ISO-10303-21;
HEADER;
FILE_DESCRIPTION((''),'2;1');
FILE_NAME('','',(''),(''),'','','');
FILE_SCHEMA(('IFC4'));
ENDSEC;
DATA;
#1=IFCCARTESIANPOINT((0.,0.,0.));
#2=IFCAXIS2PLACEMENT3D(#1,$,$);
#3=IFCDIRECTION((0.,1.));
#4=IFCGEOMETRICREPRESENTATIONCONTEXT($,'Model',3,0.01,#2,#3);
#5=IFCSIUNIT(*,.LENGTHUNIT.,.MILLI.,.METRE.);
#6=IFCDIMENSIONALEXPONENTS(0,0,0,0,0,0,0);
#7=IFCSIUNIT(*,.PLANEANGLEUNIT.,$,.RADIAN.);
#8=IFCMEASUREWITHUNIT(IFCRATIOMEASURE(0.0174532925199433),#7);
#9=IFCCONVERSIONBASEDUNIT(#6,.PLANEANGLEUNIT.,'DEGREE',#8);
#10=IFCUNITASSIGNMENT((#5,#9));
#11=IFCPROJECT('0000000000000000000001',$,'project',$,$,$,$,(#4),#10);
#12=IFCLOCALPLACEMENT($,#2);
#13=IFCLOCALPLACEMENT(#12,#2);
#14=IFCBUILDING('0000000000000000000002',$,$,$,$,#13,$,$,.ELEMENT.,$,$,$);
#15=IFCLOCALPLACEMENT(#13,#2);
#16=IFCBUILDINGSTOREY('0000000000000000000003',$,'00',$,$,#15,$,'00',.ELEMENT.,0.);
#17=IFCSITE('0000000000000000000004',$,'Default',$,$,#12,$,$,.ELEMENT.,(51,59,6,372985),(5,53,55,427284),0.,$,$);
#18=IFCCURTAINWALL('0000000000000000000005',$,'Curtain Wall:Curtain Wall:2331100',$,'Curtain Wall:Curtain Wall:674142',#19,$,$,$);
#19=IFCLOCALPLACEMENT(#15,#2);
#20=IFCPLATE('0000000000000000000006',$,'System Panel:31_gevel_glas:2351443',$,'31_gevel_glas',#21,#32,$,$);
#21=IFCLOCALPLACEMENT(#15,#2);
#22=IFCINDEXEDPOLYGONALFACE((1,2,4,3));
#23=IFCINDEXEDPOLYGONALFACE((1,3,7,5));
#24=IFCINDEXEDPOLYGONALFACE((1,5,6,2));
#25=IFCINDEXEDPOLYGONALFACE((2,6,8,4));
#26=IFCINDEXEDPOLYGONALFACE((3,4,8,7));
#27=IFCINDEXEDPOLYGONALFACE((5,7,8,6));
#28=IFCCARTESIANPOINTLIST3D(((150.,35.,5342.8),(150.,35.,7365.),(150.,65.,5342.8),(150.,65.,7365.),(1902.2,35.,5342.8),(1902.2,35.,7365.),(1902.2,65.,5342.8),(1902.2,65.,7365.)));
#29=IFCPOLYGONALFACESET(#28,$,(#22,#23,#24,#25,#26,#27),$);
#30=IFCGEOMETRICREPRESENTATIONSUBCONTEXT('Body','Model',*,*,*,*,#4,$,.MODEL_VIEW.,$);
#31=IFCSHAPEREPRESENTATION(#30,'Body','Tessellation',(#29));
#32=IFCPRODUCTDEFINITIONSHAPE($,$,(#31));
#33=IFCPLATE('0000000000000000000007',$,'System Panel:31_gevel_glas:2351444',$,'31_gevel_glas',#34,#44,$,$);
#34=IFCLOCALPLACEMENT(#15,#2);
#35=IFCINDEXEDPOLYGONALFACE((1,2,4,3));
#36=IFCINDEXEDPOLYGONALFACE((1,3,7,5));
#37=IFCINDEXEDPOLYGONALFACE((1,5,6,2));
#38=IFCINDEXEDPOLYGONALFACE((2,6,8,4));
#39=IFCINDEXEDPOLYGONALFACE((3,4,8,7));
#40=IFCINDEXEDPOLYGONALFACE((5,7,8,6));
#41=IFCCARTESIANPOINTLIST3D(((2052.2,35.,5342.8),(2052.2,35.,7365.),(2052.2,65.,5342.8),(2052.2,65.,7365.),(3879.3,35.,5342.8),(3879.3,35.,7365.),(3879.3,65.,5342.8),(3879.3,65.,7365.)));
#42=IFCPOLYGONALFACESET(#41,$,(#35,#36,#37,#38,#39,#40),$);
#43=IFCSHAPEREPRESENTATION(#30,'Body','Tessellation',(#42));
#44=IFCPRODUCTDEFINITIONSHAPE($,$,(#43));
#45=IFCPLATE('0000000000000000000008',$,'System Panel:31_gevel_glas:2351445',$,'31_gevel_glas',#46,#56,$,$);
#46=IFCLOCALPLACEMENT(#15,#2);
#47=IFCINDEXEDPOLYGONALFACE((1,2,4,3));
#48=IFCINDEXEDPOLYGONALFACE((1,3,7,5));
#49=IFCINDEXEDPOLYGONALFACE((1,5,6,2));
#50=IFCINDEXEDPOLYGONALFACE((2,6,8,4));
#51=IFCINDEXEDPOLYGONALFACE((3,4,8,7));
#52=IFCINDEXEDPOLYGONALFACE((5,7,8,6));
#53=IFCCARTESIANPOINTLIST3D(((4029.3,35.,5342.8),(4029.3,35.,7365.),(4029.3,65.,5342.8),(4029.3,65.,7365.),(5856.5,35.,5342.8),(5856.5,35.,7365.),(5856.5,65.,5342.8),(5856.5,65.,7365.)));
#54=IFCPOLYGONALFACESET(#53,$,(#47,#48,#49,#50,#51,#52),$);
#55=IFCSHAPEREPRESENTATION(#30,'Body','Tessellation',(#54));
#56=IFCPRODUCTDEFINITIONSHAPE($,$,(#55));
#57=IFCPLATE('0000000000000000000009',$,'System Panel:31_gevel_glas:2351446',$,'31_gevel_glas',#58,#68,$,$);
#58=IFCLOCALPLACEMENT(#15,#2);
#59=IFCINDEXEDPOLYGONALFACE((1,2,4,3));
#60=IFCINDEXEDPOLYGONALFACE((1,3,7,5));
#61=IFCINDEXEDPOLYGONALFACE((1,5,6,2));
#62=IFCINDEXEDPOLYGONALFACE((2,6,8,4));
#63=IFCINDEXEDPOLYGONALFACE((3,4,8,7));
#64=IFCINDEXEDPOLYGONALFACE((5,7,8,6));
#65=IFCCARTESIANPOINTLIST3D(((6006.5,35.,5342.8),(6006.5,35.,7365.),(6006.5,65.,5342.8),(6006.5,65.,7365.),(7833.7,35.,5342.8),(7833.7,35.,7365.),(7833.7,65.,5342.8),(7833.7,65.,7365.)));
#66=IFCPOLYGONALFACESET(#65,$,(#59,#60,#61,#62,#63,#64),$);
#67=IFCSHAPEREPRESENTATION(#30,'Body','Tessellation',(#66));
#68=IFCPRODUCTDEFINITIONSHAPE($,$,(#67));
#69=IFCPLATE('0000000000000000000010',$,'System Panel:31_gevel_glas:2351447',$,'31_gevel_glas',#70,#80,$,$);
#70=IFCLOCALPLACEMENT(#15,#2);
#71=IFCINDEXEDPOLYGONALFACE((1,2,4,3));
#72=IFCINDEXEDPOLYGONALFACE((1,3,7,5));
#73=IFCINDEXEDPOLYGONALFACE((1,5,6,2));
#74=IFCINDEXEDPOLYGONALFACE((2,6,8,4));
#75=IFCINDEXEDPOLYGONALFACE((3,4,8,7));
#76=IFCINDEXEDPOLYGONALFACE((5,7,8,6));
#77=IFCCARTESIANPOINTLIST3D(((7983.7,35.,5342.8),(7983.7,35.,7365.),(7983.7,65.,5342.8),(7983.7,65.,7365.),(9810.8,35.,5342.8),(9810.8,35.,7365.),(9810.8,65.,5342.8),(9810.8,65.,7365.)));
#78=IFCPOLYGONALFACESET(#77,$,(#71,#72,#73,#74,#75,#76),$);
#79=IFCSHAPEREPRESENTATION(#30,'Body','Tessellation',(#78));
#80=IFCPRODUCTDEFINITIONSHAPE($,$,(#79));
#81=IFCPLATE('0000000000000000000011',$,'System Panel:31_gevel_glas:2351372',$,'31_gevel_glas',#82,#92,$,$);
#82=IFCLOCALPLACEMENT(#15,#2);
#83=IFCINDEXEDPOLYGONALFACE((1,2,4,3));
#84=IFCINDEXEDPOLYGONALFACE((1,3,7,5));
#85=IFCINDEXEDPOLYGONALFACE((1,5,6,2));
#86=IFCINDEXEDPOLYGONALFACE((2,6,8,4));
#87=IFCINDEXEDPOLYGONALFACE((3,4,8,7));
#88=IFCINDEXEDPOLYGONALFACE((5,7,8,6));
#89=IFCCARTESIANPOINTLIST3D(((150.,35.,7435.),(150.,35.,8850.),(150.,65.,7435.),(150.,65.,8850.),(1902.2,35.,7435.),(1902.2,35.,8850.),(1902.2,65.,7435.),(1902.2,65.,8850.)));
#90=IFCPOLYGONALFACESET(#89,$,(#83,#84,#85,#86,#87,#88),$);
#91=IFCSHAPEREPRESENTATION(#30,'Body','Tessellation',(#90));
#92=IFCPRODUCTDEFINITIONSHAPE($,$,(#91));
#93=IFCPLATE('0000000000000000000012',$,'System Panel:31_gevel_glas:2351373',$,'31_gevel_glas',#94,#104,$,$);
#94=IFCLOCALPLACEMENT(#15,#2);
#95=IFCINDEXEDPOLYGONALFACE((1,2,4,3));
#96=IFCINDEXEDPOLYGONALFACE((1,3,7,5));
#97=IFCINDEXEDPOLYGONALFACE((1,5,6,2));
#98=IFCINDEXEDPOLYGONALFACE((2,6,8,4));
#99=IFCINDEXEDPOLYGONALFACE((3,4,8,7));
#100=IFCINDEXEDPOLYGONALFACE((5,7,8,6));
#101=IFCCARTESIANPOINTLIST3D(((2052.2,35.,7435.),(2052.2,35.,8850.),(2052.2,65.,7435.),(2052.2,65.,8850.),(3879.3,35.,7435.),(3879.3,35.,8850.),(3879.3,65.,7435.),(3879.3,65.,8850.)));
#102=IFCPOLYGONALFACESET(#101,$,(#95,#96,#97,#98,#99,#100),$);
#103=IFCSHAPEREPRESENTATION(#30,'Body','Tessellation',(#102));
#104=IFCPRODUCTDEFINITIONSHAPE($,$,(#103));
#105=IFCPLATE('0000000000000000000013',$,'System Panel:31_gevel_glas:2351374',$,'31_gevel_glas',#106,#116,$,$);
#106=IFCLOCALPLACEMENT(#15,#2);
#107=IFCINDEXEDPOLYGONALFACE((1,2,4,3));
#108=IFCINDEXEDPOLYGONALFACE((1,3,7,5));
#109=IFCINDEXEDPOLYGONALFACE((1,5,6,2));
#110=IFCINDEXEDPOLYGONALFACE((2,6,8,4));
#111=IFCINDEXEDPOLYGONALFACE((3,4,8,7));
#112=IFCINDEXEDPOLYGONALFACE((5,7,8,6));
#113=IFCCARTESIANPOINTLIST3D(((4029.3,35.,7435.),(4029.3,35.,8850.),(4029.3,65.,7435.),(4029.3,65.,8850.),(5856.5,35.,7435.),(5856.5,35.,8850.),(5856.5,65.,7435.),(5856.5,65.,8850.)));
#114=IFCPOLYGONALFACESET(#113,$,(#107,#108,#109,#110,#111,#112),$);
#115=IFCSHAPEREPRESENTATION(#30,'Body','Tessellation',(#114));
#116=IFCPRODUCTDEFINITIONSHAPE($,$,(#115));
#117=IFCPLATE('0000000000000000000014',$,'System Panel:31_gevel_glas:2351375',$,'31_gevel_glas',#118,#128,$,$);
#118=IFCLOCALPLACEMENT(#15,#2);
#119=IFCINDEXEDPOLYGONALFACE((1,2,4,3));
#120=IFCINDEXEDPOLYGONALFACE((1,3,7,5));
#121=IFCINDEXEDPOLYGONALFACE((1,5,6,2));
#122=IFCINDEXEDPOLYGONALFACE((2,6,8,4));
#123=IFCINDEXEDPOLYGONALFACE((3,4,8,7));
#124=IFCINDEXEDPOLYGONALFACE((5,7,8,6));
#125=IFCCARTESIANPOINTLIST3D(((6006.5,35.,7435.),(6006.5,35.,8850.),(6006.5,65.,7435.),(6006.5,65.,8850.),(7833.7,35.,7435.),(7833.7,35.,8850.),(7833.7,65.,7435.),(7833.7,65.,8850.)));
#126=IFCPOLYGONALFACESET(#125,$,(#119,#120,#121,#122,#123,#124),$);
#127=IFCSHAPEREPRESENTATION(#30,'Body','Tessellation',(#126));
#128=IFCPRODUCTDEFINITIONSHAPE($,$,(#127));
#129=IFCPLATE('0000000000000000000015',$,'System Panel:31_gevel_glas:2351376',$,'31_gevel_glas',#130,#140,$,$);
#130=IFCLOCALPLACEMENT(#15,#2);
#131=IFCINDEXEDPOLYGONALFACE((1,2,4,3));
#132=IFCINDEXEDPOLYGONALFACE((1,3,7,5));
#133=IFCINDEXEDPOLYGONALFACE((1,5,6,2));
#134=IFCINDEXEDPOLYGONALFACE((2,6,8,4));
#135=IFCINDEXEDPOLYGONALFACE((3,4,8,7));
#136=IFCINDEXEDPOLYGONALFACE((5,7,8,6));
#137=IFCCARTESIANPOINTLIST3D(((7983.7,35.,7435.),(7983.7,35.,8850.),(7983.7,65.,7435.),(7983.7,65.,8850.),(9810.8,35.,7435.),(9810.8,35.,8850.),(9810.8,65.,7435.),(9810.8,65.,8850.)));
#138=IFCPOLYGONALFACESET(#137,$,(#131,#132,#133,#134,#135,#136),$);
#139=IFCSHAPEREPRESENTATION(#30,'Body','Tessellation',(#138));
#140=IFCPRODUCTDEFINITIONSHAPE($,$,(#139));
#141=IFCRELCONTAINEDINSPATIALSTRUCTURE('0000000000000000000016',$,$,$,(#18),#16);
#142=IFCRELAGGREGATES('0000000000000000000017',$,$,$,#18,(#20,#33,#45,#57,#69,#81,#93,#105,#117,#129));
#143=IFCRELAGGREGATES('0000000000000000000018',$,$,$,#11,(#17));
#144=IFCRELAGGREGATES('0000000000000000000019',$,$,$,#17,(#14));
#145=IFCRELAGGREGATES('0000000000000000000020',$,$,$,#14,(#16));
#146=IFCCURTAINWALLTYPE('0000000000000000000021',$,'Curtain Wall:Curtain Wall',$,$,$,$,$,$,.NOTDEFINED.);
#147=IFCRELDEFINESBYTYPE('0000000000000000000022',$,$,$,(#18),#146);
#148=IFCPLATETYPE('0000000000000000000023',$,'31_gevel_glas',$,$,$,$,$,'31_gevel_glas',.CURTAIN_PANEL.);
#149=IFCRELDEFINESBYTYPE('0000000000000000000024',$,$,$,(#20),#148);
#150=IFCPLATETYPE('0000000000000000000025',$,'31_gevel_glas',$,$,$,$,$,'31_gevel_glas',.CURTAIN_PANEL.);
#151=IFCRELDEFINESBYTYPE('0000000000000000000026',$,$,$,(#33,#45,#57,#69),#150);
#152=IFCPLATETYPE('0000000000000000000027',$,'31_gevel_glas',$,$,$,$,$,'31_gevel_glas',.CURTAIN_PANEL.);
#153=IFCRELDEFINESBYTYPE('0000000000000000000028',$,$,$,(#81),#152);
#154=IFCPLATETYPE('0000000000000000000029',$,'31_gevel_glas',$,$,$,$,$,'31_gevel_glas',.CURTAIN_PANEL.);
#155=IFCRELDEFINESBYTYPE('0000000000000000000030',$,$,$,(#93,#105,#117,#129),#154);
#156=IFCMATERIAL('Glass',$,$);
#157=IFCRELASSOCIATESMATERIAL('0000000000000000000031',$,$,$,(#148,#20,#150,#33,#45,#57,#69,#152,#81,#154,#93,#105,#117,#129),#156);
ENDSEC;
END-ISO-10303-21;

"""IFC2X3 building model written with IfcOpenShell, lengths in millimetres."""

from ifc_helpers import new_model, entity, si_unit, converted_unit, direction, frame, frame_2d, origin, origin_2d_with_axis, place, context, subcontext, project, spatial, rectangle, extrude, source, transform, mapped, material, type_object, type_shapes, element, aggregate, save


model = new_model("IFC2X3")

# Units and contexts
model_context = context("Model", 3, precision=0.01, world=origin(), true_north=direction((0.0, 1.0)))
body_context = subcontext(model_context, "Body", "Model", "MODEL_VIEW")
ifc_project = project(units=[si_unit("LENGTHUNIT", "METRE", prefix="MILLI"), converted_unit("PLANEANGLEUNIT", "DEGREE", entity("IfcRatioMeasure", 0.0174532925199433), si_unit("PLANEANGLEUNIT", "RADIAN"), dimensions=[0, 0, 0, 0, 0, 0, 0])], contexts=[model_context])

# Site, building, storey
site_placement = place(None, origin())
site = spatial("IfcSite", under=ifc_project, at=site_placement, Name="Default", CompositionType="ELEMENT", RefLatitude=(51, 59, 6, 372985), RefLongitude=(5, 53, 55, 427284), RefElevation=0.0)
building_placement = place(site_placement, origin())
building = spatial("IfcBuilding", under=site, at=building_placement, CompositionType="ELEMENT")
storey_placement = place(building_placement, origin())
storey = spatial("IfcBuildingStorey", under=building, at=storey_placement, Name="00", LongName="00", CompositionType="ELEMENT", Elevation=0.0)

# Curtain wall, plates
curtain_wall_type = type_object("IfcCurtainWallType", Name="Curtain Wall:Curtain Wall", PredefinedType="NOTDEFINED")
curtain_wall_placement = place(storey_placement, origin())
curtain_wall = element("IfcCurtainWall", 1, at=curtain_wall_placement, inside=storey, type_object=curtain_wall_type, Name="Curtain Wall:Curtain Wall:2331100", ObjectType="Curtain Wall:Curtain Wall:674142")
ifc_material = material(Name="Glass")
plate_type_1 = type_object("IfcPlateType", Name="31_gevel_glas", ElementType="31_gevel_glas", PredefinedType="CURTAIN_PANEL", material=ifc_material)
shared_shape_1 = source(origin(), body_context, "Body", "SweptSolid", [
    extrude(rectangle(XDim=30.0, YDim=1752.2, at=origin_2d_with_axis()), frame((0.0, 50.0, 0.0), z_axis=(0.0, 0.0, 1.0), x_axis=(0.0, 1.0, 0.0)), (0.0, 0.0, 1.0), 2022.2),
])
type_shapes(plate_type_1, [shared_shape_1])
plate_1_placement = place(curtain_wall_placement, frame((1026.1, 0.0, 5342.8)))
plate_1 = element("IfcPlate", 2, at=plate_1_placement, type_object=plate_type_1, material=ifc_material, Name="System Panel:31_gevel_glas:2351443", ObjectType="31_gevel_glas", context=body_context, shape_type="MappedRepresentation", body=[
    mapped(shared_shape_1, transform((0.0, 0.0, 0.0), scale=1.0)),
])
plate_type_2 = type_object("IfcPlateType", Name="31_gevel_glas", ElementType="31_gevel_glas", PredefinedType="CURTAIN_PANEL", material=ifc_material)
shared_shape_2 = source(origin(), body_context, "Body", "SweptSolid", [
    extrude(rectangle(XDim=30.0, YDim=1827.2, at=origin_2d_with_axis()), frame((0.0, 50.0, 0.0), z_axis=(0.0, 0.0, 1.0), x_axis=(0.0, 1.0, 0.0)), (0.0, 0.0, 1.0), 2022.2),
])
type_shapes(plate_type_2, [shared_shape_2])
plate_2_placement = place(curtain_wall_placement, frame((2965.7, 0.0, 5342.8)))
plate_2 = element("IfcPlate", 3, at=plate_2_placement, type_object=plate_type_2, material=ifc_material, Name="System Panel:31_gevel_glas:2351444", ObjectType="31_gevel_glas", context=body_context, shape_type="MappedRepresentation", body=[
    mapped(shared_shape_2, transform((0.0, 0.0, 0.0), scale=1.0)),
])
plate_3_placement = place(curtain_wall_placement, frame((4942.9, 0.0, 5342.8)))
plate_3 = element("IfcPlate", 4, at=plate_3_placement, type_object=plate_type_2, material=ifc_material, Name="System Panel:31_gevel_glas:2351445", ObjectType="31_gevel_glas", context=body_context, shape_type="MappedRepresentation", body=[
    mapped(shared_shape_2, transform((0.0, 0.0, 0.0), scale=1.0)),
])
plate_4_placement = place(curtain_wall_placement, frame((6920.1, 0.0, 5342.8)))
plate_4 = element("IfcPlate", 5, at=plate_4_placement, type_object=plate_type_2, material=ifc_material, Name="System Panel:31_gevel_glas:2351446", ObjectType="31_gevel_glas", context=body_context, shape_type="MappedRepresentation", body=[
    mapped(shared_shape_2, transform((0.0, 0.0, 0.0), scale=1.0)),
])
plate_5_placement = place(curtain_wall_placement, frame((8897.2, 0.0, 5342.8)))
plate_5 = element("IfcPlate", 6, at=plate_5_placement, type_object=plate_type_2, material=ifc_material, Name="System Panel:31_gevel_glas:2351447", ObjectType="31_gevel_glas", context=body_context, shape_type="MappedRepresentation", body=[
    mapped(shared_shape_2, transform((0.0, 0.0, 0.0), scale=1.0)),
])
plate_type_3 = type_object("IfcPlateType", Name="31_gevel_glas", ElementType="31_gevel_glas", PredefinedType="CURTAIN_PANEL", material=ifc_material)
shared_shape_3 = source(origin(), body_context, "Body", "SweptSolid", [
    extrude(rectangle(XDim=30.0, YDim=1752.2, at=frame_2d((0.0, 0.0), x_axis=(1.0, 0.0))), frame((0.0, 50.0, 0.0), z_axis=(0.0, 0.0, 1.0), x_axis=(0.0, 1.0, 0.0)), (0.0, 0.0, 1.0), 1415.0),
])
type_shapes(plate_type_3, [shared_shape_3])
plate_6_placement = place(curtain_wall_placement, frame((1026.1, 0.0, 7435.0)))
plate_6 = element("IfcPlate", 7, at=plate_6_placement, type_object=plate_type_3, material=ifc_material, Name="System Panel:31_gevel_glas:2351372", ObjectType="31_gevel_glas", context=body_context, shape_type="MappedRepresentation", body=[
    mapped(shared_shape_3, transform((0.0, 0.0, 0.0), scale=1.0)),
])
plate_type_4 = type_object("IfcPlateType", Name="31_gevel_glas", ElementType="31_gevel_glas", PredefinedType="CURTAIN_PANEL", material=ifc_material)
shared_shape_4 = source(origin(), body_context, "Body", "SweptSolid", [
    extrude(rectangle(XDim=30.0, YDim=1827.2, at=origin_2d_with_axis()), frame((0.0, 50.0, 0.0), z_axis=(0.0, 0.0, 1.0), x_axis=(0.0, 1.0, 0.0)), (0.0, 0.0, 1.0), 1415.0),
])
type_shapes(plate_type_4, [shared_shape_4])
plate_7_placement = place(curtain_wall_placement, frame((2965.7, 0.0, 7435.0)))
plate_7 = element("IfcPlate", 8, at=plate_7_placement, type_object=plate_type_4, material=ifc_material, Name="System Panel:31_gevel_glas:2351373", ObjectType="31_gevel_glas", context=body_context, shape_type="MappedRepresentation", body=[
    mapped(shared_shape_4, transform((0.0, 0.0, 0.0), scale=1.0)),
])
plate_8_placement = place(curtain_wall_placement, frame((4942.9, 0.0, 7435.0)))
plate_8 = element("IfcPlate", 9, at=plate_8_placement, type_object=plate_type_4, material=ifc_material, Name="System Panel:31_gevel_glas:2351374", ObjectType="31_gevel_glas", context=body_context, shape_type="MappedRepresentation", body=[
    mapped(shared_shape_4, transform((0.0, 0.0, 0.0), scale=1.0)),
])
plate_9_placement = place(curtain_wall_placement, frame((6920.1, 0.0, 7435.0)))
plate_9 = element("IfcPlate", 10, at=plate_9_placement, type_object=plate_type_4, material=ifc_material, Name="System Panel:31_gevel_glas:2351375", ObjectType="31_gevel_glas", context=body_context, shape_type="MappedRepresentation", body=[
    mapped(shared_shape_4, transform((0.0, 0.0, 0.0), scale=1.0)),
])
plate_10_placement = place(curtain_wall_placement, frame((8897.2, 0.0, 7435.0)))
plate_10 = element("IfcPlate", 11, at=plate_10_placement, type_object=plate_type_4, material=ifc_material, Name="System Panel:31_gevel_glas:2351376", ObjectType="31_gevel_glas", context=body_context, shape_type="MappedRepresentation", body=[
    mapped(shared_shape_4, transform((0.0, 0.0, 0.0), scale=1.0)),
])
aggregate(curtain_wall, [plate_1, plate_2, plate_3, plate_4, plate_5, plate_6, plate_7, plate_8, plate_9, plate_10])

save(model, "model.ifc")
